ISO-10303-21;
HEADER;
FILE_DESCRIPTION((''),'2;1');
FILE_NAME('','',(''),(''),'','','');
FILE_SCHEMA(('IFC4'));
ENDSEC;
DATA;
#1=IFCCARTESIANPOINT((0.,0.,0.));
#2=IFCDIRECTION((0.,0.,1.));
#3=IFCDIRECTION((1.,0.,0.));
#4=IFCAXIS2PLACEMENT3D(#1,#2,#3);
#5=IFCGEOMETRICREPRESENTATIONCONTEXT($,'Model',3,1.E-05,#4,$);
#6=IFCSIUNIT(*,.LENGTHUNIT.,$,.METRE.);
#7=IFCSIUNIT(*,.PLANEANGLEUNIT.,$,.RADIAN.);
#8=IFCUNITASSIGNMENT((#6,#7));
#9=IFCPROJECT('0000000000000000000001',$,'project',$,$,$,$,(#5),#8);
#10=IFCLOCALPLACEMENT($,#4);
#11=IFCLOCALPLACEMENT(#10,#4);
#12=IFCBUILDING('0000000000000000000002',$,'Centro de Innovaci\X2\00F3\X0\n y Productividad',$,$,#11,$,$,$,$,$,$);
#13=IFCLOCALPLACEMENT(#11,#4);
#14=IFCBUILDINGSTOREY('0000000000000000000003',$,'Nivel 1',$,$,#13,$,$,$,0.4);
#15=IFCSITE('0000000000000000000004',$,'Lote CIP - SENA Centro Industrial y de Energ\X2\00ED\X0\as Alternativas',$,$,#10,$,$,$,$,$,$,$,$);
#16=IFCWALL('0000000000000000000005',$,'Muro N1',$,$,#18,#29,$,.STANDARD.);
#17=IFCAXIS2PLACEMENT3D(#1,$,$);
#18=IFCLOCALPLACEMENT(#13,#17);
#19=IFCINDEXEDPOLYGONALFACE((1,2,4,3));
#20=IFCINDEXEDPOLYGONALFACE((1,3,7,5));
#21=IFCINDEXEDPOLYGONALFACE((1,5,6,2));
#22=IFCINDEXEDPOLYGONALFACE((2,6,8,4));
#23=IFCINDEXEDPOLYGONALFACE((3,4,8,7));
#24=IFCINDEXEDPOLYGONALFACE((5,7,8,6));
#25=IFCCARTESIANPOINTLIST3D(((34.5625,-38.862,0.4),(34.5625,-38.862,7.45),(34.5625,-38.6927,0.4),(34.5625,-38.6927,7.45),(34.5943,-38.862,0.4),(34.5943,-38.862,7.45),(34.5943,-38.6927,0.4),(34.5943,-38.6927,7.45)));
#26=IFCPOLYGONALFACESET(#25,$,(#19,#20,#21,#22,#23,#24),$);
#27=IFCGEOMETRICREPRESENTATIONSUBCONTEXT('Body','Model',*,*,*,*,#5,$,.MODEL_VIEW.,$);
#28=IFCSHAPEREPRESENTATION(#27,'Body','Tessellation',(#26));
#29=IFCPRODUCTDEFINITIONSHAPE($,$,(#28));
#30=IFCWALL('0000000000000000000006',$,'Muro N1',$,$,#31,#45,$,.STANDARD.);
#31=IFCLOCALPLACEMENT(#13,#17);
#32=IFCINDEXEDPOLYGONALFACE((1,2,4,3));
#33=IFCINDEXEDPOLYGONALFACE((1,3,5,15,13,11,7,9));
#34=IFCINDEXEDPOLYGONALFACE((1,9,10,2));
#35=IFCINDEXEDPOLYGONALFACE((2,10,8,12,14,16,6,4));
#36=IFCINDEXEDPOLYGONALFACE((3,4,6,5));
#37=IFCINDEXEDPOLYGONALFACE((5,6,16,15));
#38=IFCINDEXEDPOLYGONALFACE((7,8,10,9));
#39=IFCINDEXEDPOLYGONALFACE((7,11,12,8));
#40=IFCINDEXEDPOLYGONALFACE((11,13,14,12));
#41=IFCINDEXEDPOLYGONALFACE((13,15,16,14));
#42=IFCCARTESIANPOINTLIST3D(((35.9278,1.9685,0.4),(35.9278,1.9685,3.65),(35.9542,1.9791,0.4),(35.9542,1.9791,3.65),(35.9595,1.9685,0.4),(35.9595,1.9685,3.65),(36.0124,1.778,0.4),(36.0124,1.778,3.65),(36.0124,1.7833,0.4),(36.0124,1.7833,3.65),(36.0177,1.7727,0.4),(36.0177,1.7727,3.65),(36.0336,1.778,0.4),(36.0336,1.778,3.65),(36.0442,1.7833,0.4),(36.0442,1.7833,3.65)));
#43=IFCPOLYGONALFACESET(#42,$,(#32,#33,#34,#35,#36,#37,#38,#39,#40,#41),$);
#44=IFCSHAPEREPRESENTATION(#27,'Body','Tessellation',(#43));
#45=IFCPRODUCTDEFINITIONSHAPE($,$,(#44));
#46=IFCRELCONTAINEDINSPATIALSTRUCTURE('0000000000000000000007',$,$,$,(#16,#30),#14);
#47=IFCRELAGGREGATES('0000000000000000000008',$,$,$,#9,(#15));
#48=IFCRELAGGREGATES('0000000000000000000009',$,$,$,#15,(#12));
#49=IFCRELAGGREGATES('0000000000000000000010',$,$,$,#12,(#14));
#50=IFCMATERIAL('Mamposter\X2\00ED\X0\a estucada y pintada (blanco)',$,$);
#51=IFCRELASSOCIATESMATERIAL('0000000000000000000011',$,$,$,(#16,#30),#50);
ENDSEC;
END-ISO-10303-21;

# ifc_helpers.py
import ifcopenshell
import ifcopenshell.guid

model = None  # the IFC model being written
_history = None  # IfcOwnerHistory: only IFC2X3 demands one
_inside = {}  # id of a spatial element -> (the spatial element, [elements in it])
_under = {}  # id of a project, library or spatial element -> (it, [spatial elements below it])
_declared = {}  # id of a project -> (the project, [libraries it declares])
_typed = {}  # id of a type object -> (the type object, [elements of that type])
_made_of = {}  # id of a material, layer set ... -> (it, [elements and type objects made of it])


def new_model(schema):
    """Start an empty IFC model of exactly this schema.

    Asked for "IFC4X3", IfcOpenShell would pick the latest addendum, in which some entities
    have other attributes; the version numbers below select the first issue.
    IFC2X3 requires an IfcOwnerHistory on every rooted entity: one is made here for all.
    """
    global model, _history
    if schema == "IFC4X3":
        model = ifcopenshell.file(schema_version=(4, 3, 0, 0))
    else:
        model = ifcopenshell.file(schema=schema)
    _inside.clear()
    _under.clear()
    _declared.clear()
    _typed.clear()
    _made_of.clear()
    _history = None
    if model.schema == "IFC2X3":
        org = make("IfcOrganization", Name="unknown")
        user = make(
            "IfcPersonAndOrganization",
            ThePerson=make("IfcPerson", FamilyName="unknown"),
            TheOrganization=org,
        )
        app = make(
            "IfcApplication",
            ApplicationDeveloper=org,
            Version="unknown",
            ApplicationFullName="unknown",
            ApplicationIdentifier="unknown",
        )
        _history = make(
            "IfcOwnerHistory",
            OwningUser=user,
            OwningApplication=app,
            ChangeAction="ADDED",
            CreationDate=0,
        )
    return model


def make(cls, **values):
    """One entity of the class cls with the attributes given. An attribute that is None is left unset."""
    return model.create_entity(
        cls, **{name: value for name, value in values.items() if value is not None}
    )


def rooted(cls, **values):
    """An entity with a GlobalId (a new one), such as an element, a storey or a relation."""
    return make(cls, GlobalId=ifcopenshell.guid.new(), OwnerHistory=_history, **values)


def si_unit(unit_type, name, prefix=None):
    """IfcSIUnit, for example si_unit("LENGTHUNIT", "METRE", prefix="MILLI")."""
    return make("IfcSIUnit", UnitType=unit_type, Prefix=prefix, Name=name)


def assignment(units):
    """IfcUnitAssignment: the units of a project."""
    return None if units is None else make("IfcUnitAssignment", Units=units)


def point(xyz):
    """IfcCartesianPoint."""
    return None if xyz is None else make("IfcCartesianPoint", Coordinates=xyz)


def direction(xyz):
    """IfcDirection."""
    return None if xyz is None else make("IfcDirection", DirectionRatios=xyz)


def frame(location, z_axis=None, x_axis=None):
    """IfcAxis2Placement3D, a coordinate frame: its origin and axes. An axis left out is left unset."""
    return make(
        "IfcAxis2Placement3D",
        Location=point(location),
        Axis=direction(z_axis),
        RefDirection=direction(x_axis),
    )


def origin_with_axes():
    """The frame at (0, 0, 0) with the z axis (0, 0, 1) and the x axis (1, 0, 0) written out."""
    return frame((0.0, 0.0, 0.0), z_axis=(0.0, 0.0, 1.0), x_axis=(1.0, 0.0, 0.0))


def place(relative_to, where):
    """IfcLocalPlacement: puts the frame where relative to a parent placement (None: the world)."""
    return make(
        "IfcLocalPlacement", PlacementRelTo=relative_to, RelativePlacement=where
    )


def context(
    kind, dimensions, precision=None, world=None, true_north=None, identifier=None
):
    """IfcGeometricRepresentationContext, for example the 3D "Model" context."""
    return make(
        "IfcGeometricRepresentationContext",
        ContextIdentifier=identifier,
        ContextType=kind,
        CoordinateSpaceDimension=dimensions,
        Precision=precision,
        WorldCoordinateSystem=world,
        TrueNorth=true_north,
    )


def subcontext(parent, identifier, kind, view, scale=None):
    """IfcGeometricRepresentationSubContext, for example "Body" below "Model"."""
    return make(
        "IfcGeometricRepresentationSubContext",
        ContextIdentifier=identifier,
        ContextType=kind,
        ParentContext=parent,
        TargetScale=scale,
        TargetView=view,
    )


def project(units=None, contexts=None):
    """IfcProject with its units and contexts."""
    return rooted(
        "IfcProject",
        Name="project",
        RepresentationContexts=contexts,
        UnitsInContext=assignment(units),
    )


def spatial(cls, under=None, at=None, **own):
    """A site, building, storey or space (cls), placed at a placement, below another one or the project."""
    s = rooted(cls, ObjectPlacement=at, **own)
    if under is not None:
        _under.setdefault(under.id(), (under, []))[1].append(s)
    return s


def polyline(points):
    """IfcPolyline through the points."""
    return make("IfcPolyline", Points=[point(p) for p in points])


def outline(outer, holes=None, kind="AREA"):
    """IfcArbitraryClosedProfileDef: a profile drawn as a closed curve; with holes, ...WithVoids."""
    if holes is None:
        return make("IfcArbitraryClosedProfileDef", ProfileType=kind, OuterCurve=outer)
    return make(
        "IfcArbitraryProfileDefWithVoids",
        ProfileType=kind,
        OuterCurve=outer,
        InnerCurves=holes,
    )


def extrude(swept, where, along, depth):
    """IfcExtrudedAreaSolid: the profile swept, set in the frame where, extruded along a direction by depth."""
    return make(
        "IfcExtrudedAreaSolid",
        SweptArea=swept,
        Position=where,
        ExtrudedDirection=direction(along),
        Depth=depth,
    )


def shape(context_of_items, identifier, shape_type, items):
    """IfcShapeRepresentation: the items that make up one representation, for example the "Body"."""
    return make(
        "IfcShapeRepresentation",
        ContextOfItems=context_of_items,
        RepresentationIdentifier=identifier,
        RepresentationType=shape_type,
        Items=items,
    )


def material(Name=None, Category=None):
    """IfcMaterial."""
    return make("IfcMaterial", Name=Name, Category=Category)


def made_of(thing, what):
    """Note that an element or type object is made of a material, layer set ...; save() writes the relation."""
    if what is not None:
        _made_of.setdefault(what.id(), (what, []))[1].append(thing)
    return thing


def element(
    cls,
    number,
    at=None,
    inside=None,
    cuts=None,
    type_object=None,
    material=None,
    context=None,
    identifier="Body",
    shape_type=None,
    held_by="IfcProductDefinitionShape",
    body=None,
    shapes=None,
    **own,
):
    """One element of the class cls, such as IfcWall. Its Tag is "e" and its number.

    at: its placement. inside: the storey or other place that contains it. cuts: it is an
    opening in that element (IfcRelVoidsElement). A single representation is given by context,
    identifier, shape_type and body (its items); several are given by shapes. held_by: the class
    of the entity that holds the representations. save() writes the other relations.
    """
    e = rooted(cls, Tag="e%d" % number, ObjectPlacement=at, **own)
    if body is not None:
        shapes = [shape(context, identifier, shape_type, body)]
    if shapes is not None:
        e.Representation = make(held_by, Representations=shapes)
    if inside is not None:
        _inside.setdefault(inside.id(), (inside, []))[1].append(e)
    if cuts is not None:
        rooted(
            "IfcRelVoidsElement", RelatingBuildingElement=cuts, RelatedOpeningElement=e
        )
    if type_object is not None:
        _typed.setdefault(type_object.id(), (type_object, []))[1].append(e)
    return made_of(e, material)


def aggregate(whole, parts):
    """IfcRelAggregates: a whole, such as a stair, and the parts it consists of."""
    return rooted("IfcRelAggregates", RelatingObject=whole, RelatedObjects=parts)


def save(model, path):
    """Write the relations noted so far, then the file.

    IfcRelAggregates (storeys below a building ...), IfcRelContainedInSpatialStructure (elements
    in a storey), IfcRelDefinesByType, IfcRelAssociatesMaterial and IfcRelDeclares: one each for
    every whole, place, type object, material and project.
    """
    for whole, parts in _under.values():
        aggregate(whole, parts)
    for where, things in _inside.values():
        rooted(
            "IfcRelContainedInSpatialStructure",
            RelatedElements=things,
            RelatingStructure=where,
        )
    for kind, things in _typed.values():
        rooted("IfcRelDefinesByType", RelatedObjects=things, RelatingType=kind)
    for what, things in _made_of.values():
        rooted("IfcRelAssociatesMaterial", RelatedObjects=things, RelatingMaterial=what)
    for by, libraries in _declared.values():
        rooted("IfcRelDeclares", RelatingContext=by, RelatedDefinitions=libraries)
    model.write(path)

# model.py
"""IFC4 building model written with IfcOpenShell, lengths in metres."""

from ifc_helpers import new_model, si_unit, frame, origin_with_axes, place, context, subcontext, project, spatial, polyline, outline, extrude, material, element, save


model = new_model("IFC4")

# Units and contexts
model_context = context("Model", 3, precision=1e-05, world=origin_with_axes())
body_context = subcontext(model_context, "Body", "Model", "MODEL_VIEW")
ifc_project = project(units=[si_unit("LENGTHUNIT", "METRE"), si_unit("PLANEANGLEUNIT", "RADIAN")], contexts=[model_context])

# Site, building, storey
site_placement = place(None, origin_with_axes())
site = spatial("IfcSite", under=ifc_project, at=site_placement, Name="Lote CIP - SENA Centro Industrial y de Energías Alternativas")
building_placement = place(site_placement, origin_with_axes())
building = spatial("IfcBuilding", under=site, at=building_placement, Name="Centro de Innovación y Productividad")
storey_placement = place(building_placement, origin_with_axes())
storey = spatial("IfcBuildingStorey", under=building, at=storey_placement, Name="Nivel 1", Elevation=0.4)

# Walls
ifc_material = material(Name="Mampostería estucada y pintada (blanco)")
wall_1_placement = place(storey_placement, origin_with_axes())
element("IfcWall", 1, at=wall_1_placement, inside=storey, material=ifc_material, Name="Muro N1", PredefinedType="STANDARD", context=body_context, shape_type="SweptSolid", body=[
    extrude(outline(polyline([(34.5625, -38.862), (34.5625, -38.6927), (34.5943, -38.6927), (34.5943, -38.862), (34.5625, -38.862)])), frame((0.0, 0.0, 0.4)), (0.0, 0.0, 1.0), 7.05),
])
wall_2_placement = place(storey_placement, origin_with_axes())
element("IfcWall", 2, at=wall_2_placement, inside=storey, material=ifc_material, Name="Muro N1", PredefinedType="STANDARD", context=body_context, shape_type="SweptSolid", body=[
    extrude(outline(polyline([(36.0442, 1.7833), (36.0336, 1.778), (36.0177, 1.7727), (36.0124, 1.778), (36.0124, 1.7833), (35.9278, 1.9685), (35.9542, 1.9791), (35.9595, 1.9685), (36.0442, 1.7833)])), frame((0.0, 0.0, 0.4)), (0.0, 0.0, 1.0), 3.25),
])

save(model, "model.ifc")
